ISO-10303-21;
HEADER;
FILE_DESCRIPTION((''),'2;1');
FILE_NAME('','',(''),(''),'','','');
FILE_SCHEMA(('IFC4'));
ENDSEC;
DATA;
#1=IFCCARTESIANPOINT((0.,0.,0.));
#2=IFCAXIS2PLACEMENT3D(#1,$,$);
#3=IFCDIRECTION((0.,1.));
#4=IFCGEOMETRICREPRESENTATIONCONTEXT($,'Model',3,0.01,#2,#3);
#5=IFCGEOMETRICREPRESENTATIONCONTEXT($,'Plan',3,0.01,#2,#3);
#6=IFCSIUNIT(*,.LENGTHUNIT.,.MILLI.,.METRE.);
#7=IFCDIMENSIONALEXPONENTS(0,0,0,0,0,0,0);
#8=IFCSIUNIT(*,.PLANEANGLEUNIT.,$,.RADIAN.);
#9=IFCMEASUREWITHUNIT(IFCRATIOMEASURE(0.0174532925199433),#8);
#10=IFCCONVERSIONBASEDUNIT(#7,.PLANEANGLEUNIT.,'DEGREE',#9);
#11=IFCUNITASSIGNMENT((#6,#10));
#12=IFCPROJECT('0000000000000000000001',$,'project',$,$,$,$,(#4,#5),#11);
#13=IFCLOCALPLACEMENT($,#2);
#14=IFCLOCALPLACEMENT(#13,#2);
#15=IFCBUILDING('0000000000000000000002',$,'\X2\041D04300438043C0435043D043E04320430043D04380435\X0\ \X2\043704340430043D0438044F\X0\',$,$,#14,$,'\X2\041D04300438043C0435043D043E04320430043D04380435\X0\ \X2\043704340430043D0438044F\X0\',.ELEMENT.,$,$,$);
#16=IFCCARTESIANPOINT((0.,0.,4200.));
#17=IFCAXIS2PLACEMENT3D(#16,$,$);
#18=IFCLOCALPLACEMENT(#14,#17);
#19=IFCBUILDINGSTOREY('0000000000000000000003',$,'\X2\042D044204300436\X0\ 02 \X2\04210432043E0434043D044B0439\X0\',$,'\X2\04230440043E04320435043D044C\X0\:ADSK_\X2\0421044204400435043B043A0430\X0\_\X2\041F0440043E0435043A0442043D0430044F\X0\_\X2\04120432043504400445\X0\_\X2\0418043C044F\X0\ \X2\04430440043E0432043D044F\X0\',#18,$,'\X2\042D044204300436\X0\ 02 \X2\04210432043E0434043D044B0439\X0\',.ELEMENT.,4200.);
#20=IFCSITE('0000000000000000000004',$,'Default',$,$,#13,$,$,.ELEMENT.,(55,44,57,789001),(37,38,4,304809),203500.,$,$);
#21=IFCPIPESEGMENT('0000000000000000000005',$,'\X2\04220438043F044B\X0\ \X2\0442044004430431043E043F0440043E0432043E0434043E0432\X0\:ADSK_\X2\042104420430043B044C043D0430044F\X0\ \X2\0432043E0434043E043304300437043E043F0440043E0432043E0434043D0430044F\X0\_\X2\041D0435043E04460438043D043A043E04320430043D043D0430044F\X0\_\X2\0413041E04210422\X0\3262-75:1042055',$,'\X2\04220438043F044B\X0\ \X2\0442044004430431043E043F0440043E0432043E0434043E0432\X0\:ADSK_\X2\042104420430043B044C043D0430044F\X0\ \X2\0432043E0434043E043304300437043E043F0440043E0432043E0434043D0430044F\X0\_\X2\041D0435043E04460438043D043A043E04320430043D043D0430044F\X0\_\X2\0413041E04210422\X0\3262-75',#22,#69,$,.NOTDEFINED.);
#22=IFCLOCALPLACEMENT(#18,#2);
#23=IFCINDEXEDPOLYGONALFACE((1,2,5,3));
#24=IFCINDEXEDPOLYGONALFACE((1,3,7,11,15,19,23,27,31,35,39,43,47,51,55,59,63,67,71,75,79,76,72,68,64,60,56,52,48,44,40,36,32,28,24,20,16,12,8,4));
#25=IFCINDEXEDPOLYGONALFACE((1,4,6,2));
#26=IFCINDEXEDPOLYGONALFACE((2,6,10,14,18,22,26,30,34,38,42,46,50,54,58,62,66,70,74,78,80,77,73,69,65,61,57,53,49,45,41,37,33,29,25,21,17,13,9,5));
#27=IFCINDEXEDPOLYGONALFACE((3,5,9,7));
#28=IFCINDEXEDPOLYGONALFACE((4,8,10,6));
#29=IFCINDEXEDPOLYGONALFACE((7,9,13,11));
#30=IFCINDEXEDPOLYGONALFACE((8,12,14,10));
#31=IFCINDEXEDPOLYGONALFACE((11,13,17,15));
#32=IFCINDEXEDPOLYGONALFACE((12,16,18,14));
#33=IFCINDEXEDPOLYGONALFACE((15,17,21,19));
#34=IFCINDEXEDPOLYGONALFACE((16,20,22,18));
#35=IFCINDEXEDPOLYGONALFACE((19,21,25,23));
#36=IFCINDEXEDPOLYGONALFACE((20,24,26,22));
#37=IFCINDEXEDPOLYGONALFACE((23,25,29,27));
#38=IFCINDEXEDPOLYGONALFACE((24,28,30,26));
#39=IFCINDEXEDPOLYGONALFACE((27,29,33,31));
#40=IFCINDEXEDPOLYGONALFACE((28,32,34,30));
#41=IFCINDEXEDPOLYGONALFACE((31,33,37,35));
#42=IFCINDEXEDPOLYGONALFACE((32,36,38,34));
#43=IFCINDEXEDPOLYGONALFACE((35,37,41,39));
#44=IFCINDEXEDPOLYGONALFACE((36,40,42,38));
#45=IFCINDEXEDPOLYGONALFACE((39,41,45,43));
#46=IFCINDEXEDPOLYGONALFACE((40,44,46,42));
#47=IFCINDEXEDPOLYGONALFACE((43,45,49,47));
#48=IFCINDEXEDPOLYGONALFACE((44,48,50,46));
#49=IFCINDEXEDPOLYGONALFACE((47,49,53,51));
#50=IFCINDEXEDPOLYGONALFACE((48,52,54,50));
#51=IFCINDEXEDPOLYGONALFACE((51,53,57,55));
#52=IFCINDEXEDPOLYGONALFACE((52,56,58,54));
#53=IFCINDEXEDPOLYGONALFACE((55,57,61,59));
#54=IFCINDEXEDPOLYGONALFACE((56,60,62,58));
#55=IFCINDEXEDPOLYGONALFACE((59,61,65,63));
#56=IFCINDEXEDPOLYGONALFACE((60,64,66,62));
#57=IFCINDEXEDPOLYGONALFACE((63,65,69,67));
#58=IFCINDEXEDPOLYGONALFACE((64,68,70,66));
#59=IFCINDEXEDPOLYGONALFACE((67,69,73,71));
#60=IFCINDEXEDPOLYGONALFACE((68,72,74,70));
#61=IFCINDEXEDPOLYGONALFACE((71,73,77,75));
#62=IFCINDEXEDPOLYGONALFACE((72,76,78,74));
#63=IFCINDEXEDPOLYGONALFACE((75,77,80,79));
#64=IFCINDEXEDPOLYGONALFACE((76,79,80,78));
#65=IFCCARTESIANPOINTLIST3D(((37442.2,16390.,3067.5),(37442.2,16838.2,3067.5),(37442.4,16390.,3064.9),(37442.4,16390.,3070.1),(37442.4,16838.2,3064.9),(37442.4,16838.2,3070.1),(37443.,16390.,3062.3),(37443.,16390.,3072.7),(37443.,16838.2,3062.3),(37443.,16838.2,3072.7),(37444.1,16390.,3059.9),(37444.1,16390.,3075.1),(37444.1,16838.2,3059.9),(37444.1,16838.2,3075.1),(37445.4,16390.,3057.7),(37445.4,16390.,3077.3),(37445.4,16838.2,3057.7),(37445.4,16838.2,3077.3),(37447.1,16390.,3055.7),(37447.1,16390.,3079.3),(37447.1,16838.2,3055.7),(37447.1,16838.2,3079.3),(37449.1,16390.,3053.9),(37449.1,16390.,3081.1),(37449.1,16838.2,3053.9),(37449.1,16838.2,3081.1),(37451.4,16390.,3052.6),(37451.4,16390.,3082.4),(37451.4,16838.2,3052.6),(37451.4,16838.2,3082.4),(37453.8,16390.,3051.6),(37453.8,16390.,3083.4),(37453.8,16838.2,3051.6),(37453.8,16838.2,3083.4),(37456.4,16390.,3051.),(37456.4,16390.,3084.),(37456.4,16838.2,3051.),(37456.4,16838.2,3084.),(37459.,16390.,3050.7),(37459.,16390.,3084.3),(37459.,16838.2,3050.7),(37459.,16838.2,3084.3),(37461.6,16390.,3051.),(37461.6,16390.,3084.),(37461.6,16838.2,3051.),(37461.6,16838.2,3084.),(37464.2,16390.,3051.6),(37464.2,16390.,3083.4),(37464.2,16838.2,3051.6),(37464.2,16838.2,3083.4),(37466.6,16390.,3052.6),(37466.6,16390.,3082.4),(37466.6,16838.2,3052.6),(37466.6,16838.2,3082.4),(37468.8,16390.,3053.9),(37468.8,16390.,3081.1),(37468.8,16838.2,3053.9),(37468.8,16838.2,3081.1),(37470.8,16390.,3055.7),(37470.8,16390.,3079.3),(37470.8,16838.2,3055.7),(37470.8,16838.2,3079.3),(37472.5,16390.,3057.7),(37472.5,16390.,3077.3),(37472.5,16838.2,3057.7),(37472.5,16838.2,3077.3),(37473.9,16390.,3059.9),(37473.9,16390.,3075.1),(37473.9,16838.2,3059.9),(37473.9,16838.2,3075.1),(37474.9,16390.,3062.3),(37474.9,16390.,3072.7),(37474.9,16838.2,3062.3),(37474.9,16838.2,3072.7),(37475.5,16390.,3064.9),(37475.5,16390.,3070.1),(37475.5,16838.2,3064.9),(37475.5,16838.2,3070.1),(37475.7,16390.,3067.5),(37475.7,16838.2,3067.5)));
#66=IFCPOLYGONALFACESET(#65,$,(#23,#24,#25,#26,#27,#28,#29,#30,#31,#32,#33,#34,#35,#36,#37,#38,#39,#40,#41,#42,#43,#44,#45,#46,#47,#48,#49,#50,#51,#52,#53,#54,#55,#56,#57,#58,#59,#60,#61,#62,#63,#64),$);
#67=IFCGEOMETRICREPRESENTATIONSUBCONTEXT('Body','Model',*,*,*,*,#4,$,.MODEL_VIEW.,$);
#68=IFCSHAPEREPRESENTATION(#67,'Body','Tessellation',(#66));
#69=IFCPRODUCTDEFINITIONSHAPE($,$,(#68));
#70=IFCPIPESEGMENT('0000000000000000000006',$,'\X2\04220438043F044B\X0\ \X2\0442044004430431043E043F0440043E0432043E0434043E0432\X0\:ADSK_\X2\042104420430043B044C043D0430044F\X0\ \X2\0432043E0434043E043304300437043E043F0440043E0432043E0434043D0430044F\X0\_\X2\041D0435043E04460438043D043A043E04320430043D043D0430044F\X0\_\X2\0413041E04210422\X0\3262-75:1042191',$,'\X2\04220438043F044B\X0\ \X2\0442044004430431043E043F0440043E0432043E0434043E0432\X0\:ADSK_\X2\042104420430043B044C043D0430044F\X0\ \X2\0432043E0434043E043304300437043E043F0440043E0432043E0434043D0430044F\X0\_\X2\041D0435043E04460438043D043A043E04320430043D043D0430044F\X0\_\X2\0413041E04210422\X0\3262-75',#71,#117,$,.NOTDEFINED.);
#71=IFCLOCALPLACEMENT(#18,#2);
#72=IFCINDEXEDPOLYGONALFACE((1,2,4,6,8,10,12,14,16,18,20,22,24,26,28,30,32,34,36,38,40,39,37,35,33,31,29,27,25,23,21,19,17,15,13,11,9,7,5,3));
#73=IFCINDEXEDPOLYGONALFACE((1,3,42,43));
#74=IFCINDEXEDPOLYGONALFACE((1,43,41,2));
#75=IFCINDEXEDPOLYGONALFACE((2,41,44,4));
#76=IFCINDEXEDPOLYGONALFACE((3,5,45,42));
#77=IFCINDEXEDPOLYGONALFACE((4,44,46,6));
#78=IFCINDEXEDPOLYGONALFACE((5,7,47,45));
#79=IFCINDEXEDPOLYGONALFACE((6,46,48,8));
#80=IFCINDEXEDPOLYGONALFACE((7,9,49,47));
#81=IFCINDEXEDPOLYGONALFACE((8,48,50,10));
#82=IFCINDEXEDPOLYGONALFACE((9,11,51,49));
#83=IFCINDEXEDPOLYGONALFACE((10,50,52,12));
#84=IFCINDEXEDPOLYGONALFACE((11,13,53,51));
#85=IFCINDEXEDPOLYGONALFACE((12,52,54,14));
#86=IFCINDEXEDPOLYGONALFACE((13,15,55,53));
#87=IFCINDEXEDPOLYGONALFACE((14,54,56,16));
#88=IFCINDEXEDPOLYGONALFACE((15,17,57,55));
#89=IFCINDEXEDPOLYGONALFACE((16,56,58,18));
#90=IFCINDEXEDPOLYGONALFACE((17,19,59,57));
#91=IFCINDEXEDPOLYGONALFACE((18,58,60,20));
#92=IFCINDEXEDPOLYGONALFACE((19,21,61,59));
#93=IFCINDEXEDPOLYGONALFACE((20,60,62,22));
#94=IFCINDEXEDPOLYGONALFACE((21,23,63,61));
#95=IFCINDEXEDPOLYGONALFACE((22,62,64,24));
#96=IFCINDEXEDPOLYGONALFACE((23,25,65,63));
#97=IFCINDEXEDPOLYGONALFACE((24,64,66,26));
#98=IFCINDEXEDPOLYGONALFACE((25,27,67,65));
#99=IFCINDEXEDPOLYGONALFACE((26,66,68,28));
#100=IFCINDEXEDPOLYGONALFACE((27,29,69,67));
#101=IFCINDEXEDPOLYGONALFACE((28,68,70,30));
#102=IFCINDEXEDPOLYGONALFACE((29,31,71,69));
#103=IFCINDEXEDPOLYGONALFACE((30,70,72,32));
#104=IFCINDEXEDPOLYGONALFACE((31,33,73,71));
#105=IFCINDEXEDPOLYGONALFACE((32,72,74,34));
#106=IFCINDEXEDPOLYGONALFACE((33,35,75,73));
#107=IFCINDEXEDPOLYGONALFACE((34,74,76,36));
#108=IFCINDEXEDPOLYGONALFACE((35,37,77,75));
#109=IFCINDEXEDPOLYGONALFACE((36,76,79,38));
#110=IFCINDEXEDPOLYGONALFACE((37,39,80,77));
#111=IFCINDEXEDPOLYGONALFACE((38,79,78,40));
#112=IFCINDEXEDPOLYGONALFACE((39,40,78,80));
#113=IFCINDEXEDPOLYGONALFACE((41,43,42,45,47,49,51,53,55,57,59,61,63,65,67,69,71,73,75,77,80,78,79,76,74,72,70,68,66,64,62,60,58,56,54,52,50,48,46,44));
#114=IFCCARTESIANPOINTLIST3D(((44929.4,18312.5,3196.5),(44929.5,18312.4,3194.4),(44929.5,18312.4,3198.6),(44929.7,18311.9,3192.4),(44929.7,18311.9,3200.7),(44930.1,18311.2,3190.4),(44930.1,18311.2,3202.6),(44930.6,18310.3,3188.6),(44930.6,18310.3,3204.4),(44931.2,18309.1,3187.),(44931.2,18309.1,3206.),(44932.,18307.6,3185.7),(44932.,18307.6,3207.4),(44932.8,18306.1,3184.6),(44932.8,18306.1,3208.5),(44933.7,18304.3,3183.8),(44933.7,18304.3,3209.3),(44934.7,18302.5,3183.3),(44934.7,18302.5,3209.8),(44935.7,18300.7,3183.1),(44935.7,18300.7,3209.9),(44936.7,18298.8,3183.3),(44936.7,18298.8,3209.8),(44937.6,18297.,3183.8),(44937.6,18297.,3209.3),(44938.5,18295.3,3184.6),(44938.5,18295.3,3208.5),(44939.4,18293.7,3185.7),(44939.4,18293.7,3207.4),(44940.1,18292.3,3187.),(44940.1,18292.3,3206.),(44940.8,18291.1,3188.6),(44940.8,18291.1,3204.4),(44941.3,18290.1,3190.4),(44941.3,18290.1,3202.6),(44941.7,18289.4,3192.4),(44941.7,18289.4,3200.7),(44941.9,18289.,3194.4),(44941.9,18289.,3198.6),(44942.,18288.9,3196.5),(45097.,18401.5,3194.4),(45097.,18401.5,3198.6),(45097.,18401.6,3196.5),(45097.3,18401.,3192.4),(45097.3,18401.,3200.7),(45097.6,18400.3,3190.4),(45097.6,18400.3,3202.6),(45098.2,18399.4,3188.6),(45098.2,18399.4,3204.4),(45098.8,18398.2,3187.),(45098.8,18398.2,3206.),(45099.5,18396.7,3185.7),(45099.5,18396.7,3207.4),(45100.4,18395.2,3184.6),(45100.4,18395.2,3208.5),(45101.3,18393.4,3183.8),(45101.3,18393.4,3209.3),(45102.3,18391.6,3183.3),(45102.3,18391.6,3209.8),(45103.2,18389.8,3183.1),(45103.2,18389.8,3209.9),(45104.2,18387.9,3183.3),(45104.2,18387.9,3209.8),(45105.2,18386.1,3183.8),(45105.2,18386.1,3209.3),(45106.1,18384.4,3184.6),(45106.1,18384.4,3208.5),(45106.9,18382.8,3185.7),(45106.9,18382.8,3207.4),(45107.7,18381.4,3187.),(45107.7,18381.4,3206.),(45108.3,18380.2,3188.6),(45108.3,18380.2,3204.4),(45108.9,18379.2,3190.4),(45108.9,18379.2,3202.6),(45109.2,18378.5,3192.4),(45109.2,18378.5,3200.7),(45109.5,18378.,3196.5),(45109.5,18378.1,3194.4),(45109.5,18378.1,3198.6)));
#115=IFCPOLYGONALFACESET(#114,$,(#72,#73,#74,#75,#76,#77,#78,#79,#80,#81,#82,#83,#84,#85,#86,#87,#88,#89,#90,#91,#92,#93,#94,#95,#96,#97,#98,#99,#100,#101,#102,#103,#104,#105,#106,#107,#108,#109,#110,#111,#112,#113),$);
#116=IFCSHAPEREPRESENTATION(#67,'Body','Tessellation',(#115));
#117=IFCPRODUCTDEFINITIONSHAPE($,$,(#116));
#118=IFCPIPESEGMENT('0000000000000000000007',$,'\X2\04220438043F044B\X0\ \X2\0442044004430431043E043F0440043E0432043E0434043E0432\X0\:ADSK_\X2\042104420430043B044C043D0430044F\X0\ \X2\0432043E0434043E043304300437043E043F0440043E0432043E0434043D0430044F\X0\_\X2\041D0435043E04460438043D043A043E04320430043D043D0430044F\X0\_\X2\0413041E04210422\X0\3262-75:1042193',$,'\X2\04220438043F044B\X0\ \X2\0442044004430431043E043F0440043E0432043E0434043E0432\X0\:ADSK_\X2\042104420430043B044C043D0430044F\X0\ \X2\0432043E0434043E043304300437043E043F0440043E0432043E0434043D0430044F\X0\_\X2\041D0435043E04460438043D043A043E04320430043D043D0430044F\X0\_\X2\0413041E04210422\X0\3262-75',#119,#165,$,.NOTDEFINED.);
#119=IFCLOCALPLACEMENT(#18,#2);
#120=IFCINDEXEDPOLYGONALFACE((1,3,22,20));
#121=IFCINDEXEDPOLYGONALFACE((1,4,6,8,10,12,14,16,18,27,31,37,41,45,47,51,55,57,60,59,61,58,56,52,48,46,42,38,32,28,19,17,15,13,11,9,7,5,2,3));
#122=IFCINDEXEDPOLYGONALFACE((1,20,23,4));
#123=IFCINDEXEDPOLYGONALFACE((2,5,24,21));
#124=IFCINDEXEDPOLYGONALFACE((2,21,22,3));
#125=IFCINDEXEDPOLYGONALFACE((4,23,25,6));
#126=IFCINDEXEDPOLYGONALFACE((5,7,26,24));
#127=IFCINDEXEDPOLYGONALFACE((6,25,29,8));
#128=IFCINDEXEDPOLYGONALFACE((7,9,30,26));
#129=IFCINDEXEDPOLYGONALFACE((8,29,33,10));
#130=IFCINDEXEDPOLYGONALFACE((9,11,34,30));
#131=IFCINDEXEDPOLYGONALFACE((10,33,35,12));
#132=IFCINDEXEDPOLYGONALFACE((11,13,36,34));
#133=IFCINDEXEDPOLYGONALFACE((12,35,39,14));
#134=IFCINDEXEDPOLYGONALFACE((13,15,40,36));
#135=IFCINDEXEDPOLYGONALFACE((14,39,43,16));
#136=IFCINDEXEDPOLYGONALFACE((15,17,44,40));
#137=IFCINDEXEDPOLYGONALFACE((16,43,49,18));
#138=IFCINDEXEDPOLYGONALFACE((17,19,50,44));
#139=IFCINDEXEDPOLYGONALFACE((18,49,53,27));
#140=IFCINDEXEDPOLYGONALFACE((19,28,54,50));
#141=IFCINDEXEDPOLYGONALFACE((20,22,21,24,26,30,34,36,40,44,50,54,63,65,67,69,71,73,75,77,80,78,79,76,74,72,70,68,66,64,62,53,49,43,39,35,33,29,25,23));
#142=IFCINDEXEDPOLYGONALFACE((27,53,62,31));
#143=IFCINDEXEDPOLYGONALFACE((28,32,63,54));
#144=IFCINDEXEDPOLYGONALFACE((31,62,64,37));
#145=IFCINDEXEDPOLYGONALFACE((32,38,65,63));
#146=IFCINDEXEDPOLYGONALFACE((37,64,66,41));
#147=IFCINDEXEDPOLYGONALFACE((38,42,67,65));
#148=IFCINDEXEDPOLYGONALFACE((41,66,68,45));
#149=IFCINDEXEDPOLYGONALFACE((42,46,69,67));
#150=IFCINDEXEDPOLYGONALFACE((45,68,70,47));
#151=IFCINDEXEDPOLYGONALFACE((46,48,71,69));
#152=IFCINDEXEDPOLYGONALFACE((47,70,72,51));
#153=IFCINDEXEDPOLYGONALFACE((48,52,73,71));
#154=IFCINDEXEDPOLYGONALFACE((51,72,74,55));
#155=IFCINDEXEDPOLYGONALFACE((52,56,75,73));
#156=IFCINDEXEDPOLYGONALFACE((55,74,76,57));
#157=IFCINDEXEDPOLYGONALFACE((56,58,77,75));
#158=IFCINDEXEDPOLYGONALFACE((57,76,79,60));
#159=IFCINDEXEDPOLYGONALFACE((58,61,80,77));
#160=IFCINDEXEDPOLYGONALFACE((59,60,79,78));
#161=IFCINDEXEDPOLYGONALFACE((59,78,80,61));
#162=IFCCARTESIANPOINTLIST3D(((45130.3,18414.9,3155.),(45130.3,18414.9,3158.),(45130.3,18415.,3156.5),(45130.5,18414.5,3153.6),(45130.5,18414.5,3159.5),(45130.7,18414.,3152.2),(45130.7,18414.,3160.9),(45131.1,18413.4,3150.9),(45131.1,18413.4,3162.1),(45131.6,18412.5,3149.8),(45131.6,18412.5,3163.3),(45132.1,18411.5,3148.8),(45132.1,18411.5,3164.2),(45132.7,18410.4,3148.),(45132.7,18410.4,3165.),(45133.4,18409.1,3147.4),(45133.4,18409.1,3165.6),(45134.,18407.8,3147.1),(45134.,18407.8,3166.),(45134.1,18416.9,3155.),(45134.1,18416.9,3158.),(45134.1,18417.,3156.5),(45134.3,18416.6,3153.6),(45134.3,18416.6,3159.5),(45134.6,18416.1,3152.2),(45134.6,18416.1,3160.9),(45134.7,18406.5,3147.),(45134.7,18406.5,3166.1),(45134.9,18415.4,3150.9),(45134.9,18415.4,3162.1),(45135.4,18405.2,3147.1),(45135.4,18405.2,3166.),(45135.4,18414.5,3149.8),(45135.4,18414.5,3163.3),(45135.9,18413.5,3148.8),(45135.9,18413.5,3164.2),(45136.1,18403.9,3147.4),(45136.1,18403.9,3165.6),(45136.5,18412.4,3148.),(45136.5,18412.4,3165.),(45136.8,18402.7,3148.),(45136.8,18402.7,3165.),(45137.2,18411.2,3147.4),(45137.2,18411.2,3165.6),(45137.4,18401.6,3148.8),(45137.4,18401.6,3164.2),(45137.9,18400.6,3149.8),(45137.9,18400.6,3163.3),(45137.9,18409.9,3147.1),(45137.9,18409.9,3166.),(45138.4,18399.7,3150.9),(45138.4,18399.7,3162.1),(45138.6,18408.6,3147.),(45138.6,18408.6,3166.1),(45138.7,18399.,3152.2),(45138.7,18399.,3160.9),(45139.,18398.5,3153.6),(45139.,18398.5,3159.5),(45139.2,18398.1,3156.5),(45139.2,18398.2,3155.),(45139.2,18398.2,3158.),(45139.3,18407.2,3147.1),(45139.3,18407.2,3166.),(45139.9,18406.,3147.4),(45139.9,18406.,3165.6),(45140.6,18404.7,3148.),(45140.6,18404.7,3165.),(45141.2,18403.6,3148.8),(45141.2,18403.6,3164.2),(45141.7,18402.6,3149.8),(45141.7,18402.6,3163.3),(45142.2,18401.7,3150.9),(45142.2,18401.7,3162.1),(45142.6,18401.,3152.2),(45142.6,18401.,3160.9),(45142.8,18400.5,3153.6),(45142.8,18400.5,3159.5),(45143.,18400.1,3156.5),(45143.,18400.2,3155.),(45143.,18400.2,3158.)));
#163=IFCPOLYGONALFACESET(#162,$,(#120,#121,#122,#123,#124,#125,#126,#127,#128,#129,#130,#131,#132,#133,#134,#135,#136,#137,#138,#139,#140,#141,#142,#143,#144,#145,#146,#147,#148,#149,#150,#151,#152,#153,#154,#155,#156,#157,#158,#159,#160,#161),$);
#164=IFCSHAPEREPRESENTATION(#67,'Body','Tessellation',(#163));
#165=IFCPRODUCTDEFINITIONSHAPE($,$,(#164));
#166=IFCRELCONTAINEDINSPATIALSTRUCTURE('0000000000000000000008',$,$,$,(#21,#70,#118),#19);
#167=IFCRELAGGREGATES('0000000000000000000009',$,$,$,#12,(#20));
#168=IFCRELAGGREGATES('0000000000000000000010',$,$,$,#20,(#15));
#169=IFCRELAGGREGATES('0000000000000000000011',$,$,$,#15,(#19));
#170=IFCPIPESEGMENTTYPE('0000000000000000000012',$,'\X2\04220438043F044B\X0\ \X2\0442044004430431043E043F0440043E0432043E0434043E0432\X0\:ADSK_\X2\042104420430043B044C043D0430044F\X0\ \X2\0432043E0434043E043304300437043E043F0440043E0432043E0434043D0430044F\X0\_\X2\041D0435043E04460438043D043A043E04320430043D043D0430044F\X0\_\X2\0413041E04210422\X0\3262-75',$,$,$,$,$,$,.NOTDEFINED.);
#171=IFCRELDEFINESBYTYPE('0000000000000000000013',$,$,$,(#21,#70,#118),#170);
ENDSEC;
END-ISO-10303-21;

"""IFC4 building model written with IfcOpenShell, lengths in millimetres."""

from ifc_helpers import new_model, entity, si_unit, converted_unit, direction, frame, origin, place, context, subcontext, project, spatial, indexed_curve, outline, extrude, type_object, element, save


model = new_model("IFC4")

# Units and contexts
model_context = context("Model", 3, precision=0.01, world=origin(), true_north=direction((0.0, 1.0)))
plan_context = context("Plan", 3, precision=0.01, world=origin(), true_north=direction((0.0, 1.0)))
body_context = subcontext(model_context, "Body", "Model", "MODEL_VIEW")
ifc_project = project(units=[si_unit("LENGTHUNIT", "METRE", prefix="MILLI"), converted_unit("PLANEANGLEUNIT", "DEGREE", entity("IfcRatioMeasure", 0.0174532925199433), si_unit("PLANEANGLEUNIT", "RADIAN"), dimensions=[0, 0, 0, 0, 0, 0, 0])], contexts=[model_context, plan_context])

# Site, building, storey
site_placement = place(None, origin())
site = spatial("IfcSite", under=ifc_project, at=site_placement, Name="Default", CompositionType="ELEMENT", RefLatitude=(55, 44, 57, 789001), RefLongitude=(37, 38, 4, 304809), RefElevation=203500.0)
building_placement = place(site_placement, origin())
building = spatial("IfcBuilding", under=site, at=building_placement, Name="Наименование здания", LongName="Наименование здания", CompositionType="ELEMENT")
storey_placement = place(building_placement, frame((0.0, 0.0, 4200.0)))
storey = spatial("IfcBuildingStorey", under=building, at=storey_placement, Name="Этаж 02 Сводный", ObjectType="Уровень:ADSK_Стрелка_Проектная_Вверх_Имя уровня", LongName="Этаж 02 Сводный", CompositionType="ELEMENT", Elevation=4200.0)

# Pipe segments
pipe_segment_type = type_object("IfcPipeSegmentType", Name="Типы трубопроводов:ADSK_Стальная водогазопроводная_Неоцинкованная_ГОСТ3262-75", PredefinedType="NOTDEFINED")
placement = place(storey_placement, origin())
element("IfcPipeSegment", 1, at=placement, inside=storey, type_object=pipe_segment_type, Name="Типы трубопроводов:ADSK_Стальная водогазопроводная_Неоцинкованная_ГОСТ3262-75:1042055", ObjectType="Типы трубопроводов:ADSK_Стальная водогазопроводная_Неоцинкованная_ГОСТ3262-75", PredefinedType="NOTDEFINED", context=body_context, shape_type="SweptSolid", body=[
    extrude(outline(indexed_curve([(16.8, 0.0), (16.5, 2.6), (15.9, 5.2), (14.9, 7.6), (13.6, 9.8), (11.8, 11.8), (9.8, 13.6), (7.6, 14.9), (5.2, 15.9), (2.6, 16.5), (0.0, 16.8), (-2.6, 16.5), (-5.2, 15.9), (-7.6, 14.9), (-9.8, 13.6), (-11.8, 11.8), (-13.6, 9.8), (-14.9, 7.6), (-15.9, 5.2), (-16.5, 2.6), (-16.8, 0.0), (-16.5, -2.6), (-15.9, -5.2), (-14.9, -7.6), (-13.6, -9.8), (-11.8, -11.8), (-9.8, -13.6), (-7.6, -14.9), (-5.2, -15.9), (-2.6, -16.5), (0.0, -16.8), (2.6, -16.5), (5.2, -15.9), (7.6, -14.9), (9.8, -13.6), (11.8, -11.8), (13.6, -9.8), (14.9, -7.6), (15.9, -5.2), (16.5, -2.6), (16.8, 0.0)], self_intersect=False)), frame((37459.0, 16390.0, 3067.5), z_axis=(0.0, 1.0, 0.0), x_axis=(-1.0, 0.0, 0.0)), (0.0, 0.0, 1.0), 448.1),
])
element("IfcPipeSegment", 2, at=placement, inside=storey, type_object=pipe_segment_type, Name="Типы трубопроводов:ADSK_Стальная водогазопроводная_Неоцинкованная_ГОСТ3262-75:1042191", ObjectType="Типы трубопроводов:ADSK_Стальная водогазопроводная_Неоцинкованная_ГОСТ3262-75", PredefinedType="NOTDEFINED", context=body_context, shape_type="SweptSolid", body=[
    extrude(outline(indexed_curve([(13.4, 0.0), (13.2, 2.1), (12.7, 4.1), (11.9, 6.1), (10.8, 7.9), (9.5, 9.5), (7.9, 10.8), (6.1, 11.9), (4.1, 12.7), (2.1, 13.2), (0.0, 13.4), (-2.1, 13.2), (-4.1, 12.7), (-6.1, 11.9), (-7.9, 10.8), (-9.5, 9.5), (-10.8, 7.9), (-11.9, 6.1), (-12.7, 4.1), (-13.2, 2.1), (-13.4, 0.0), (-13.2, -2.1), (-12.7, -4.1), (-11.9, -6.1), (-10.8, -7.9), (-9.5, -9.5), (-7.9, -10.8), (-6.1, -11.9), (-4.1, -12.7), (-2.1, -13.2), (0.0, -13.4), (2.1, -13.2), (4.1, -12.7), (6.1, -11.9), (7.9, -10.8), (9.5, -9.5), (10.8, -7.9), (11.9, -6.1), (12.7, -4.1), (13.2, -2.1), (13.4, 0.0)], self_intersect=False)), frame((44935.7, 18300.7, 3196.5), z_axis=(0.882948, 0.469472, 0.0), x_axis=(-0.469472, 0.882948, 0.0)), (0.0, 0.0, 1.0), 189.8),
])
element("IfcPipeSegment", 3, at=placement, inside=storey, type_object=pipe_segment_type, Name="Типы трубопроводов:ADSK_Стальная водогазопроводная_Неоцинкованная_ГОСТ3262-75:1042193", ObjectType="Типы трубопроводов:ADSK_Стальная водогазопроводная_Неоцинкованная_ГОСТ3262-75", PredefinedType="NOTDEFINED", context=body_context, shape_type="SweptSolid", body=[
    extrude(outline(indexed_curve([(9.6, 0.0), (9.4, 1.5), (9.1, 3.0), (8.5, 4.3), (7.7, 5.6), (6.8, 6.8), (5.6, 7.7), (4.3, 8.5), (3.0, 9.1), (1.5, 9.4), (0.0, 9.6), (-1.5, 9.4), (-3.0, 9.1), (-4.3, 8.5), (-5.6, 7.7), (-6.8, 6.8), (-7.7, 5.6), (-8.5, 4.3), (-9.1, 3.0), (-9.4, 1.5), (-9.6, 0.0), (-9.4, -1.5), (-9.1, -3.0), (-8.5, -4.3), (-7.7, -5.6), (-6.8, -6.8), (-5.6, -7.7), (-4.3, -8.5), (-3.0, -9.1), (-1.5, -9.4), (0.0, -9.6), (1.5, -9.4), (3.0, -9.1), (4.3, -8.5), (5.6, -7.7), (6.8, -6.8), (7.7, -5.6), (8.5, -4.3), (9.1, -3.0), (9.4, -1.5), (9.6, 0.0)], self_intersect=False)), frame((45134.7, 18406.5, 3156.5), z_axis=(0.882948, 0.469472, 0.0), x_axis=(-0.469472, 0.882948, 0.0)), (0.0, 0.0, 1.0), 4.3),
])

save(model, "model.ifc")
